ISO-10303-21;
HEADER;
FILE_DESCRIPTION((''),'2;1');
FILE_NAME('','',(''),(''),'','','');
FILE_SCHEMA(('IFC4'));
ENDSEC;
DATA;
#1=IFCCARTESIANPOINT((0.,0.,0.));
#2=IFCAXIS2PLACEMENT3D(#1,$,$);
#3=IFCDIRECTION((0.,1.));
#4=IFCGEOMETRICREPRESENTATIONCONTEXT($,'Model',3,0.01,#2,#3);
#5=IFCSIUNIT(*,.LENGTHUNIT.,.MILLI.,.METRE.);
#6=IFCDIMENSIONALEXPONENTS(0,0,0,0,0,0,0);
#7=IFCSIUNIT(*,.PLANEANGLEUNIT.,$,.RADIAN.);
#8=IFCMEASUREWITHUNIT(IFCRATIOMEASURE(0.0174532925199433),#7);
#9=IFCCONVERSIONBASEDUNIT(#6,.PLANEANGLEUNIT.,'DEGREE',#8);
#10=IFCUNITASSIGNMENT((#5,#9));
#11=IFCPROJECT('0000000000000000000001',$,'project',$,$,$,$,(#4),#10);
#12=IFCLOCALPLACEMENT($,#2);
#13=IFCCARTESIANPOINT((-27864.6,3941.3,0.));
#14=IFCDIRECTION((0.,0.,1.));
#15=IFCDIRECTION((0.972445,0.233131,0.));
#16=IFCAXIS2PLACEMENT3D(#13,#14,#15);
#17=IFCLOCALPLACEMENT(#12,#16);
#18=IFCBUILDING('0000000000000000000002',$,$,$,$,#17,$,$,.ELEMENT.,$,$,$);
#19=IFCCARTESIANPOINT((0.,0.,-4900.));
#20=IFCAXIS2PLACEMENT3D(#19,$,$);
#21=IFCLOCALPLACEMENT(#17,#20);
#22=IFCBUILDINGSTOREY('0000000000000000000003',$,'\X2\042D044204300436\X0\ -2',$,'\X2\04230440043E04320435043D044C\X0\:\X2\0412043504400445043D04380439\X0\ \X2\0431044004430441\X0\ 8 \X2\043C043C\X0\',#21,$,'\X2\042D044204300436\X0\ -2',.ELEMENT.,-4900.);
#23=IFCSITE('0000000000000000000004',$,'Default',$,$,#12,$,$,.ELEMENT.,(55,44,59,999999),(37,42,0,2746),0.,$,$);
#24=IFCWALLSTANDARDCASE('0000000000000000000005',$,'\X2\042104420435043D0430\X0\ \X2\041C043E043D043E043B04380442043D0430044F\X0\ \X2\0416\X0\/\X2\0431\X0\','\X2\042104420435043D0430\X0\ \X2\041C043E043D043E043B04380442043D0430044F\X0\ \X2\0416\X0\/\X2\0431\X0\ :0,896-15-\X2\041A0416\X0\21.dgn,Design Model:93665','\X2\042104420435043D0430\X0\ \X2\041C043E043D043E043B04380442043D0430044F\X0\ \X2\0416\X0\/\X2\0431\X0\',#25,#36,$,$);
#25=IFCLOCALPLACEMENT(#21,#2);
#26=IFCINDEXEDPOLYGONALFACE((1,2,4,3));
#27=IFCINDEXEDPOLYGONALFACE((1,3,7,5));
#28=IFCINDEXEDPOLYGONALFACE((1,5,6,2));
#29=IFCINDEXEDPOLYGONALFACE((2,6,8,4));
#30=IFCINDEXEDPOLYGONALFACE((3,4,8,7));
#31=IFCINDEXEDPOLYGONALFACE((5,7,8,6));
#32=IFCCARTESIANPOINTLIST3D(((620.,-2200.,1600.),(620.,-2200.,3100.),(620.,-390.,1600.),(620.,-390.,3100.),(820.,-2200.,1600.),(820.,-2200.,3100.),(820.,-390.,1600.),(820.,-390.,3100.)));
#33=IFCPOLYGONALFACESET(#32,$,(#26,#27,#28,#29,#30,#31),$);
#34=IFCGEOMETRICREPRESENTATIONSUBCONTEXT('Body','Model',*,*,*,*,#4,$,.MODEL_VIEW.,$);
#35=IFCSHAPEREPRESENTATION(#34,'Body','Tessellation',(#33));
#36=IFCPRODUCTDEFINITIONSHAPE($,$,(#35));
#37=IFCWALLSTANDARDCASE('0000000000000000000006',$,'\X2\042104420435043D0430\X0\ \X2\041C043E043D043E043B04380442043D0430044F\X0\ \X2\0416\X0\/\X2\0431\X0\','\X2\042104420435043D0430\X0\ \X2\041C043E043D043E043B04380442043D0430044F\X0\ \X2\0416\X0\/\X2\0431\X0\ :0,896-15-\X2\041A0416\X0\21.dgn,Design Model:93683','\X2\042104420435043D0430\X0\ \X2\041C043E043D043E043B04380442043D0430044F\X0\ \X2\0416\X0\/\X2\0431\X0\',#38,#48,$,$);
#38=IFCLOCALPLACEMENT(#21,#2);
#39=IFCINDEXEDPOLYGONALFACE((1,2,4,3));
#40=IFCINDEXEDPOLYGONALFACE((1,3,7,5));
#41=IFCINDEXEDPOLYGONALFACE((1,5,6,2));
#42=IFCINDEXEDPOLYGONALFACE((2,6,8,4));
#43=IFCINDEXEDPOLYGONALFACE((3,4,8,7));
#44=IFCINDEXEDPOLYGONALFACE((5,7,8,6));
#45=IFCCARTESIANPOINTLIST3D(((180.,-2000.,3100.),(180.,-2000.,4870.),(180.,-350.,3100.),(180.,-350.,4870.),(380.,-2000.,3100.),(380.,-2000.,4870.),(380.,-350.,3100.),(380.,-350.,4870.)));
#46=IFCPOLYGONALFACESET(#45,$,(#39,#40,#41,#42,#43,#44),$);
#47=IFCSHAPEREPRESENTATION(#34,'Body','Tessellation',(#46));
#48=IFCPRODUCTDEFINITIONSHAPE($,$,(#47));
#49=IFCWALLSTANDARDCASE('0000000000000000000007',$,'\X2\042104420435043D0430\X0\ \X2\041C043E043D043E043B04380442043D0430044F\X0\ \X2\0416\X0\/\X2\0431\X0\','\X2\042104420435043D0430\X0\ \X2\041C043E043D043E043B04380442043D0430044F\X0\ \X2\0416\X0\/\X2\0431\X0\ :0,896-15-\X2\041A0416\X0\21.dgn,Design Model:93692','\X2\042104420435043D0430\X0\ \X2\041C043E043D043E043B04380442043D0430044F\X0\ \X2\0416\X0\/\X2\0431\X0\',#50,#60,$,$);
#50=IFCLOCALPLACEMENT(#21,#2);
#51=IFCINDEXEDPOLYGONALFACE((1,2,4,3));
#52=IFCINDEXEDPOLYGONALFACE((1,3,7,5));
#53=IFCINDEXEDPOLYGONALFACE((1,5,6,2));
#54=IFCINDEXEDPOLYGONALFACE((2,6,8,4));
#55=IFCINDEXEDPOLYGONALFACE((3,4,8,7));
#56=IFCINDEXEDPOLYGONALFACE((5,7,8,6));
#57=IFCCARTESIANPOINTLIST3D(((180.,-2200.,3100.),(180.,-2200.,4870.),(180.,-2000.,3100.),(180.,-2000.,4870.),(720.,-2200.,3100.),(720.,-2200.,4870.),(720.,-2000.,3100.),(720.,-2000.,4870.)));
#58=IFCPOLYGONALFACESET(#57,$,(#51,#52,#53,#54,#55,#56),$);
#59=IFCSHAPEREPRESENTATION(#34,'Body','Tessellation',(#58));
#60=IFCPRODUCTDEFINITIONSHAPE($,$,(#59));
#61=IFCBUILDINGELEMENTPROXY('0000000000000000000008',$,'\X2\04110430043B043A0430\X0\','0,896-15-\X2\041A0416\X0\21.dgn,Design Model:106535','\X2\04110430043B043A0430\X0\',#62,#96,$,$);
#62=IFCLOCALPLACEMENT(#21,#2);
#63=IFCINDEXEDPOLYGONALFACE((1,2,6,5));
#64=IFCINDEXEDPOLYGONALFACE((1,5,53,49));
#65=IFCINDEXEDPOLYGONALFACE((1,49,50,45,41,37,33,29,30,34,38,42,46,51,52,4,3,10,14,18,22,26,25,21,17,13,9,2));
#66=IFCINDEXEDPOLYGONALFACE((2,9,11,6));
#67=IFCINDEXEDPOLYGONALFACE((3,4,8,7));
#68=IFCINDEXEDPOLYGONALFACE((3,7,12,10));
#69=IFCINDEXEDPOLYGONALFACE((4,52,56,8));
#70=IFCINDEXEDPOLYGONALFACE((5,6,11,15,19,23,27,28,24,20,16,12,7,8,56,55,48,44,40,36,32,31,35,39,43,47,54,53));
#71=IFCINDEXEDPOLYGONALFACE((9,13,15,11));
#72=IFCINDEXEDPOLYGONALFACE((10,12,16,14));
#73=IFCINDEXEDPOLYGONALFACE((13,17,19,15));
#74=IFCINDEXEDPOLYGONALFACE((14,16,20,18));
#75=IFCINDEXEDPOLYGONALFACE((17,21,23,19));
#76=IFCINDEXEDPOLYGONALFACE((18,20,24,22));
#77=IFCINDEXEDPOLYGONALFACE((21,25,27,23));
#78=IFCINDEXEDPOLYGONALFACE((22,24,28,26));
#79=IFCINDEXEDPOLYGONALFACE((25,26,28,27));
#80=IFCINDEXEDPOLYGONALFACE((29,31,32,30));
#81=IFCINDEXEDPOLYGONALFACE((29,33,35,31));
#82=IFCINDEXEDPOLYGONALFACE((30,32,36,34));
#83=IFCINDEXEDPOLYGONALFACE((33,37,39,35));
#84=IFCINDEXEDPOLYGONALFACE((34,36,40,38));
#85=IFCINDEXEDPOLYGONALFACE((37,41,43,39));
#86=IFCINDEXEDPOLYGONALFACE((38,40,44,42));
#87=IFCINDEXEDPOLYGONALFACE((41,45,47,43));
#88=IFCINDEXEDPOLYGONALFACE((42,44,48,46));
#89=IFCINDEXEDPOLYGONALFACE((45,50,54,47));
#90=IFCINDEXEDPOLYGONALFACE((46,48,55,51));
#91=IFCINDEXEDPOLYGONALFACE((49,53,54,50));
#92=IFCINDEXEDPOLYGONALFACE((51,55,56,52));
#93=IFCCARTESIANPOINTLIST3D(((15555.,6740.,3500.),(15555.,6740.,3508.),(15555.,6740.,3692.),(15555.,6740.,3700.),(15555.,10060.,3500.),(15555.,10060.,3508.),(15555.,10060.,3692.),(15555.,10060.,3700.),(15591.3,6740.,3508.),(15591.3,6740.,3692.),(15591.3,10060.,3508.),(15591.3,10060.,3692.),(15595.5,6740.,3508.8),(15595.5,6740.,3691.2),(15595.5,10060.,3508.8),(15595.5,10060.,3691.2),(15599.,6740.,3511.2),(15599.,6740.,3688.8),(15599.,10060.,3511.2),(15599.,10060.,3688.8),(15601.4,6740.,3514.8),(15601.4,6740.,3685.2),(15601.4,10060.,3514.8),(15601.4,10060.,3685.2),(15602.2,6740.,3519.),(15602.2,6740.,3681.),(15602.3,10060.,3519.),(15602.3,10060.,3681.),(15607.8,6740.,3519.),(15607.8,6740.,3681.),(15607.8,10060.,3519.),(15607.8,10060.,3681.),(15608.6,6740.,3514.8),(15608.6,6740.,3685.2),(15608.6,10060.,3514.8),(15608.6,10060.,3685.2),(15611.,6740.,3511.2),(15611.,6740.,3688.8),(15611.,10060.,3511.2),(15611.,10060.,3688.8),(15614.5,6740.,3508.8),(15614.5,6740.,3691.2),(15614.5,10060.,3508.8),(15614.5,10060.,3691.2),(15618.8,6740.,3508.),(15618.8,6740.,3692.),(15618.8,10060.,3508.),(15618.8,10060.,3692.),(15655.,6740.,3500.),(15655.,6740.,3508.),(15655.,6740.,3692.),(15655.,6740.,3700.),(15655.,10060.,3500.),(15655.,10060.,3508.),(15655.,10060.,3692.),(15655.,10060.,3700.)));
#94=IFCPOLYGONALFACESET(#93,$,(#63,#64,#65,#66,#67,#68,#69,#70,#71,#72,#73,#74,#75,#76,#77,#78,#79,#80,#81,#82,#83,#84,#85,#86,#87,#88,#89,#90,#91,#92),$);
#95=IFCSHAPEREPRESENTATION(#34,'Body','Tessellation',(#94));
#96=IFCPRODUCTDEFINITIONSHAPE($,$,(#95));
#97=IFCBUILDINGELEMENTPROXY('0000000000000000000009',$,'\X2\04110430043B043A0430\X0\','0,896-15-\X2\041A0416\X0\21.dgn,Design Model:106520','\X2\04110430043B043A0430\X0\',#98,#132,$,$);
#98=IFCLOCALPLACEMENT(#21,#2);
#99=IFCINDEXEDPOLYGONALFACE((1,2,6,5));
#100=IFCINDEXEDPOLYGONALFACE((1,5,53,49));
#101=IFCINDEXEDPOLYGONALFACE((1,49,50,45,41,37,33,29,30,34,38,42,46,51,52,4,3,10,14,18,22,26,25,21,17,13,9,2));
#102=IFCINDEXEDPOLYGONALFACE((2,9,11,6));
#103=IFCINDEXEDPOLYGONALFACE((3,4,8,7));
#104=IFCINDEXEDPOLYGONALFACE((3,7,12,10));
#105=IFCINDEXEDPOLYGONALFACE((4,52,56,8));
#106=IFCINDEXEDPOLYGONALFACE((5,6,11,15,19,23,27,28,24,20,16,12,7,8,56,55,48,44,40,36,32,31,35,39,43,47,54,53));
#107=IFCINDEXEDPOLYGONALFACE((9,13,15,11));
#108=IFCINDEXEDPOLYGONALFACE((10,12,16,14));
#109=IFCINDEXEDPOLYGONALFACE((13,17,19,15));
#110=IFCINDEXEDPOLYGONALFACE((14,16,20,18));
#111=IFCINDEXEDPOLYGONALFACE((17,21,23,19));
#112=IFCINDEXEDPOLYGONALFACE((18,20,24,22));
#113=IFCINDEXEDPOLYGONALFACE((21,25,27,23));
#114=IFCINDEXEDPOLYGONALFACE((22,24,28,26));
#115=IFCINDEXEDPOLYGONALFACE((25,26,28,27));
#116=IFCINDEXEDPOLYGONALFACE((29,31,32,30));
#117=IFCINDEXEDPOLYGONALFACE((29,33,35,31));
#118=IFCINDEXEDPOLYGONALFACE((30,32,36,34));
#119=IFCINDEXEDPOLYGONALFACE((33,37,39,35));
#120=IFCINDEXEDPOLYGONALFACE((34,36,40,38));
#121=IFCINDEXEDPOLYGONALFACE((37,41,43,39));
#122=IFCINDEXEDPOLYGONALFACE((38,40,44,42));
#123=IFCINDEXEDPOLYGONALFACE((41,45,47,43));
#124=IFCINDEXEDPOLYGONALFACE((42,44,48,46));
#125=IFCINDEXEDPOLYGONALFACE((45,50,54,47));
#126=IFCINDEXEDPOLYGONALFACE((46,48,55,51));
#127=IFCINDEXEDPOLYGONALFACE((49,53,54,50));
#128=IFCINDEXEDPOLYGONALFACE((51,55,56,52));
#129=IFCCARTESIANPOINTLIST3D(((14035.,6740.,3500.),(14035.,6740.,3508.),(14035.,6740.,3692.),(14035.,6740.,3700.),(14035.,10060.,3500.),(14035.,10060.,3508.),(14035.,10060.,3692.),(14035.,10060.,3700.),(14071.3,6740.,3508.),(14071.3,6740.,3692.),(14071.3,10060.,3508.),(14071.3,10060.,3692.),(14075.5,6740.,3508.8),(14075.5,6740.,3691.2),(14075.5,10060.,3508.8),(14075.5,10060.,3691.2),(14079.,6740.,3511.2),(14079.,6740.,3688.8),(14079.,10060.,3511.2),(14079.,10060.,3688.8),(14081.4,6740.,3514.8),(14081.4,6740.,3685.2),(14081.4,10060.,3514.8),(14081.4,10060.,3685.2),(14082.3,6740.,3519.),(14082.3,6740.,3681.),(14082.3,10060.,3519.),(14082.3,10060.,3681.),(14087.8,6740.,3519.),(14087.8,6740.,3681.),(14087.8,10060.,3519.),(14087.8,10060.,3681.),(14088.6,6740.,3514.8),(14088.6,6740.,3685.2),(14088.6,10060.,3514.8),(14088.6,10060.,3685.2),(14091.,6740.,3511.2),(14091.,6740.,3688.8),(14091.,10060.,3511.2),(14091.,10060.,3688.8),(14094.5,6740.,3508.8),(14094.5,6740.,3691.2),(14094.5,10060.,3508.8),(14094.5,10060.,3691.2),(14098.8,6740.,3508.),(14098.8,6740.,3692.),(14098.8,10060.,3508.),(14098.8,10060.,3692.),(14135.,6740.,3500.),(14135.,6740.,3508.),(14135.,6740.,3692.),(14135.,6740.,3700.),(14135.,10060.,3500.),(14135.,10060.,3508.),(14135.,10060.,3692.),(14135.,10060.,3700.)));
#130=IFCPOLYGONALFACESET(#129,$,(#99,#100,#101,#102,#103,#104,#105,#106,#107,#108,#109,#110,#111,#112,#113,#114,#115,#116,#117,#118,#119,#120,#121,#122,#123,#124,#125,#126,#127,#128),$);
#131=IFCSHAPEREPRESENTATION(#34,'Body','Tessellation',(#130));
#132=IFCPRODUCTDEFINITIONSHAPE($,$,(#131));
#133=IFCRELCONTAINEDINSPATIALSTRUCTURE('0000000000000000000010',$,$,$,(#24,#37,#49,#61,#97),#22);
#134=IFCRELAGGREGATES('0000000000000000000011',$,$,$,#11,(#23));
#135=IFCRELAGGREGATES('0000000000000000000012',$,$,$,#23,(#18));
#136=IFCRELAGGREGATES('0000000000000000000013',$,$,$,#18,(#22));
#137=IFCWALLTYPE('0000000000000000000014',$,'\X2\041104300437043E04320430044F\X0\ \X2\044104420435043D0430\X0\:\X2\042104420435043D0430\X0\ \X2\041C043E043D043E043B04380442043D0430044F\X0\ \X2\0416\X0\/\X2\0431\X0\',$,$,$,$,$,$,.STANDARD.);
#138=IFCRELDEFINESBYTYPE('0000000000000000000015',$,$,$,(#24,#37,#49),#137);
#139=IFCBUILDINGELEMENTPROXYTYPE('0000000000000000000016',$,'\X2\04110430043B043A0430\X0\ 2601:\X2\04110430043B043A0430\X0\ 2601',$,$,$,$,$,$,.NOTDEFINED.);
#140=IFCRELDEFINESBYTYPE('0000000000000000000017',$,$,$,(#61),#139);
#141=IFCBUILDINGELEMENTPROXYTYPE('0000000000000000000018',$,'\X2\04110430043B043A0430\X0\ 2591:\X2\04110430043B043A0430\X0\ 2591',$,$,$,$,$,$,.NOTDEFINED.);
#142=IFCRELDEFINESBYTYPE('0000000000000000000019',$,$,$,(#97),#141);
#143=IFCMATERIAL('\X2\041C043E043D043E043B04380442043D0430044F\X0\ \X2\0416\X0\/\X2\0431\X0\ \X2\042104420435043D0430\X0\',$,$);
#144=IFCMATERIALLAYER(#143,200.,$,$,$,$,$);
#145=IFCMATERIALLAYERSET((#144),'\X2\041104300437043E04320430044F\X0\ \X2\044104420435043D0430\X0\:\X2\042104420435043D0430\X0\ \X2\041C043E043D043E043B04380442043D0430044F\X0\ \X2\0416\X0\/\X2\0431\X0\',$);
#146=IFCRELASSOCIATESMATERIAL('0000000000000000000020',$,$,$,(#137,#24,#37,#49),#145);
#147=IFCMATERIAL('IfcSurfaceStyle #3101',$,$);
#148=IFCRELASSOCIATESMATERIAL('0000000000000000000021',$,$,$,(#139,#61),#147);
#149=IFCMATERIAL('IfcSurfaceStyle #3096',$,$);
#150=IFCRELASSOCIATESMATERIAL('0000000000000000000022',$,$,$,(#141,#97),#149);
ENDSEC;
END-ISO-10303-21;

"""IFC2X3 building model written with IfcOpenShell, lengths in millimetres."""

from ifc_helpers import new_model, entity, si_unit, converted_unit, direction, frame, frame_2d, origin, place, context, subcontext, project, spatial, polyline, rectangle, outline, extrude, source, transform, mapped, material, layer, layer_set, layer_usage, type_object, type_shapes, element, save


model = new_model("IFC2X3")

# Units and contexts
model_context = context("Model", 3, precision=0.01, world=origin(), true_north=direction((0.0, 1.0)))
body_context = subcontext(model_context, "Body", "Model", "MODEL_VIEW")
ifc_project = project(units=[si_unit("LENGTHUNIT", "METRE", prefix="MILLI"), converted_unit("PLANEANGLEUNIT", "DEGREE", entity("IfcRatioMeasure", 0.0174532925199433), si_unit("PLANEANGLEUNIT", "RADIAN"), dimensions=[0, 0, 0, 0, 0, 0, 0])], contexts=[model_context])

# Site, building, storey
site_placement = place(None, origin())
site = spatial("IfcSite", under=ifc_project, at=site_placement, Name="Default", CompositionType="ELEMENT", RefLatitude=(55, 44, 59, 999999), RefLongitude=(37, 42, 0, 2746), RefElevation=0.0)
building_placement = place(site_placement, frame((-27864.6, 3941.3, 0.0), z_axis=(0.0, 0.0, 1.0), x_axis=(0.972445, 0.233131, 0.0)))
building = spatial("IfcBuilding", under=site, at=building_placement, CompositionType="ELEMENT")
storey_placement = place(building_placement, frame((0.0, 0.0, -4900.0)))
storey = spatial("IfcBuildingStorey", under=building, at=storey_placement, Name="Этаж -2", ObjectType="Уровень:Верхний брус 8 мм", LongName="Этаж -2", CompositionType="ELEMENT", Elevation=-4900.0)

# Walls
ifc_material_1 = material(Name="Монолитная Ж/б Стена")
ifc_layer = layer(ifc_material_1, 200.0)
ifc_layer_set = layer_set([ifc_layer], Name="Базовая стена:Стена Монолитная Ж/б")
ifc_layer_usage = layer_usage(ifc_layer_set, "AXIS2", "NEGATIVE", 100.0)
wall_type = type_object("IfcWallType", Name="Базовая стена:Стена Монолитная Ж/б", PredefinedType="STANDARD", material=ifc_layer_set)
wall_1_placement = place(storey_placement, frame((720.0, -2200.0, 1600.0), z_axis=(0.0, 0.0, 1.0), x_axis=(0.0, 1.0, 0.0)))
element("IfcWallStandardCase", 1, at=wall_1_placement, inside=storey, type_object=wall_type, material=ifc_layer_usage, Name="Стена Монолитная Ж/б", Description="Стена Монолитная Ж/б :0,896-15-КЖ21.dgn,Design Model:93665", ObjectType="Стена Монолитная Ж/б", context=body_context, shape_type="SweptSolid", body=[
    extrude(rectangle(XDim=1810.0, YDim=200.0, at=frame_2d((905.0, 0.0), x_axis=(-1.0, 0.0))), origin(), (0.0, 0.0, 1.0), 1500.0),
])
wall_2_placement = place(storey_placement, frame((280.0, -2000.0, 3100.0), z_axis=(0.0, 0.0, 1.0), x_axis=(0.0, 1.0, 0.0)))
element("IfcWallStandardCase", 2, at=wall_2_placement, inside=storey, type_object=wall_type, material=ifc_layer_usage, Name="Стена Монолитная Ж/б", Description="Стена Монолитная Ж/б :0,896-15-КЖ21.dgn,Design Model:93683", ObjectType="Стена Монолитная Ж/б", context=body_context, shape_type="SweptSolid", body=[
    extrude(rectangle(XDim=1650.0, YDim=200.0, at=frame_2d((825.0, 0.0), x_axis=(-1.0, 0.0))), origin(), (0.0, 0.0, 1.0), 1770.0),
])
wall_3_placement = place(storey_placement, frame((720.0, -2100.0, 3100.0), z_axis=(0.0, 0.0, 1.0), x_axis=(-1.0, 0.0, 0.0)))
element("IfcWallStandardCase", 3, at=wall_3_placement, inside=storey, type_object=wall_type, material=ifc_layer_usage, Name="Стена Монолитная Ж/б", Description="Стена Монолитная Ж/б :0,896-15-КЖ21.dgn,Design Model:93692", ObjectType="Стена Монолитная Ж/б", context=body_context, shape_type="SweptSolid", body=[
    extrude(rectangle(XDim=540.0, YDim=200.0, at=frame_2d((270.0, 0.0), x_axis=(-1.0, 0.0))), origin(), (0.0, 0.0, 1.0), 1770.0),
])

# Building element proxies
placement = place(storey_placement, frame((0.0, 0.0, 4900.0)))
ifc_material_2 = material(Name="IfcSurfaceStyle #3101")
building_element_proxy_type_1 = type_object("IfcBuildingElementProxyType", Name="Балка 2601:Балка 2601", PredefinedType="NOTDEFINED", material=ifc_material_2)
shared_shape_1 = source(origin(), body_context, "Body", "SweptSolid", [
    extrude(outline(polyline([(92.0, -50.0), (100.0, -50.0), (100.0, 50.0), (92.0, 50.0), (92.0, 13.8), (91.2, 9.5), (88.8, 6.0), (85.2, 3.6), (81.0, 2.8), (-81.0, 2.8), (-85.2, 3.6), (-88.8, 6.0), (-91.2, 9.5), (-92.0, 13.8), (-92.0, 50.0), (-100.0, 50.0), (-100.0, -50.0), (-92.0, -50.0), (-92.0, -13.8), (-91.2, -9.5), (-88.8, -6.0), (-85.2, -3.6), (-81.0, -2.8), (81.0, -2.8), (85.2, -3.6), (88.8, -6.0), (91.2, -9.5), (92.0, -13.8), (92.0, -50.0)])), frame((15605.0, 6740.0, -1300.0), z_axis=(0.0, 1.0, 0.0), x_axis=(0.0, 0.0, -1.0)), (0.0, 0.0, 1.0), 3320.0),
])
type_shapes(building_element_proxy_type_1, [shared_shape_1])
element("IfcBuildingElementProxy", 4, at=placement, inside=storey, type_object=building_element_proxy_type_1, material=ifc_material_2, Name="Балка", Description="0,896-15-КЖ21.dgn,Design Model:106535", ObjectType="Балка", context=body_context, shape_type="MappedRepresentation", body=[
    mapped(shared_shape_1, transform((0.0, 0.0, 0.0), scale=1.0)),
])
ifc_material_3 = material(Name="IfcSurfaceStyle #3096")
building_element_proxy_type_2 = type_object("IfcBuildingElementProxyType", Name="Балка 2591:Балка 2591", PredefinedType="NOTDEFINED", material=ifc_material_3)
shared_shape_2 = source(origin(), body_context, "Body", "SweptSolid", [
    extrude(outline(polyline([(92.0, -50.0), (100.0, -50.0), (100.0, 50.0), (92.0, 50.0), (92.0, 13.8), (91.2, 9.5), (88.8, 6.0), (85.2, 3.6), (81.0, 2.8), (-81.0, 2.8), (-85.2, 3.6), (-88.8, 6.0), (-91.2, 9.5), (-92.0, 13.8), (-92.0, 50.0), (-100.0, 50.0), (-100.0, -50.0), (-92.0, -50.0), (-92.0, -13.8), (-91.2, -9.5), (-88.8, -6.0), (-85.2, -3.6), (-81.0, -2.8), (81.0, -2.8), (85.2, -3.6), (88.8, -6.0), (91.2, -9.5), (92.0, -13.8), (92.0, -50.0)])), frame((14085.0, 6740.0, -1300.0), z_axis=(0.0, 1.0, 0.0), x_axis=(0.0, 0.0, -1.0)), (0.0, 0.0, 1.0), 3320.0),
])
type_shapes(building_element_proxy_type_2, [shared_shape_2])
element("IfcBuildingElementProxy", 5, at=placement, inside=storey, type_object=building_element_proxy_type_2, material=ifc_material_3, Name="Балка", Description="0,896-15-КЖ21.dgn,Design Model:106520", ObjectType="Балка", context=body_context, shape_type="MappedRepresentation", body=[
    mapped(shared_shape_2, transform((0.0, 0.0, 0.0), scale=1.0)),
])

save(model, "model.ifc")
